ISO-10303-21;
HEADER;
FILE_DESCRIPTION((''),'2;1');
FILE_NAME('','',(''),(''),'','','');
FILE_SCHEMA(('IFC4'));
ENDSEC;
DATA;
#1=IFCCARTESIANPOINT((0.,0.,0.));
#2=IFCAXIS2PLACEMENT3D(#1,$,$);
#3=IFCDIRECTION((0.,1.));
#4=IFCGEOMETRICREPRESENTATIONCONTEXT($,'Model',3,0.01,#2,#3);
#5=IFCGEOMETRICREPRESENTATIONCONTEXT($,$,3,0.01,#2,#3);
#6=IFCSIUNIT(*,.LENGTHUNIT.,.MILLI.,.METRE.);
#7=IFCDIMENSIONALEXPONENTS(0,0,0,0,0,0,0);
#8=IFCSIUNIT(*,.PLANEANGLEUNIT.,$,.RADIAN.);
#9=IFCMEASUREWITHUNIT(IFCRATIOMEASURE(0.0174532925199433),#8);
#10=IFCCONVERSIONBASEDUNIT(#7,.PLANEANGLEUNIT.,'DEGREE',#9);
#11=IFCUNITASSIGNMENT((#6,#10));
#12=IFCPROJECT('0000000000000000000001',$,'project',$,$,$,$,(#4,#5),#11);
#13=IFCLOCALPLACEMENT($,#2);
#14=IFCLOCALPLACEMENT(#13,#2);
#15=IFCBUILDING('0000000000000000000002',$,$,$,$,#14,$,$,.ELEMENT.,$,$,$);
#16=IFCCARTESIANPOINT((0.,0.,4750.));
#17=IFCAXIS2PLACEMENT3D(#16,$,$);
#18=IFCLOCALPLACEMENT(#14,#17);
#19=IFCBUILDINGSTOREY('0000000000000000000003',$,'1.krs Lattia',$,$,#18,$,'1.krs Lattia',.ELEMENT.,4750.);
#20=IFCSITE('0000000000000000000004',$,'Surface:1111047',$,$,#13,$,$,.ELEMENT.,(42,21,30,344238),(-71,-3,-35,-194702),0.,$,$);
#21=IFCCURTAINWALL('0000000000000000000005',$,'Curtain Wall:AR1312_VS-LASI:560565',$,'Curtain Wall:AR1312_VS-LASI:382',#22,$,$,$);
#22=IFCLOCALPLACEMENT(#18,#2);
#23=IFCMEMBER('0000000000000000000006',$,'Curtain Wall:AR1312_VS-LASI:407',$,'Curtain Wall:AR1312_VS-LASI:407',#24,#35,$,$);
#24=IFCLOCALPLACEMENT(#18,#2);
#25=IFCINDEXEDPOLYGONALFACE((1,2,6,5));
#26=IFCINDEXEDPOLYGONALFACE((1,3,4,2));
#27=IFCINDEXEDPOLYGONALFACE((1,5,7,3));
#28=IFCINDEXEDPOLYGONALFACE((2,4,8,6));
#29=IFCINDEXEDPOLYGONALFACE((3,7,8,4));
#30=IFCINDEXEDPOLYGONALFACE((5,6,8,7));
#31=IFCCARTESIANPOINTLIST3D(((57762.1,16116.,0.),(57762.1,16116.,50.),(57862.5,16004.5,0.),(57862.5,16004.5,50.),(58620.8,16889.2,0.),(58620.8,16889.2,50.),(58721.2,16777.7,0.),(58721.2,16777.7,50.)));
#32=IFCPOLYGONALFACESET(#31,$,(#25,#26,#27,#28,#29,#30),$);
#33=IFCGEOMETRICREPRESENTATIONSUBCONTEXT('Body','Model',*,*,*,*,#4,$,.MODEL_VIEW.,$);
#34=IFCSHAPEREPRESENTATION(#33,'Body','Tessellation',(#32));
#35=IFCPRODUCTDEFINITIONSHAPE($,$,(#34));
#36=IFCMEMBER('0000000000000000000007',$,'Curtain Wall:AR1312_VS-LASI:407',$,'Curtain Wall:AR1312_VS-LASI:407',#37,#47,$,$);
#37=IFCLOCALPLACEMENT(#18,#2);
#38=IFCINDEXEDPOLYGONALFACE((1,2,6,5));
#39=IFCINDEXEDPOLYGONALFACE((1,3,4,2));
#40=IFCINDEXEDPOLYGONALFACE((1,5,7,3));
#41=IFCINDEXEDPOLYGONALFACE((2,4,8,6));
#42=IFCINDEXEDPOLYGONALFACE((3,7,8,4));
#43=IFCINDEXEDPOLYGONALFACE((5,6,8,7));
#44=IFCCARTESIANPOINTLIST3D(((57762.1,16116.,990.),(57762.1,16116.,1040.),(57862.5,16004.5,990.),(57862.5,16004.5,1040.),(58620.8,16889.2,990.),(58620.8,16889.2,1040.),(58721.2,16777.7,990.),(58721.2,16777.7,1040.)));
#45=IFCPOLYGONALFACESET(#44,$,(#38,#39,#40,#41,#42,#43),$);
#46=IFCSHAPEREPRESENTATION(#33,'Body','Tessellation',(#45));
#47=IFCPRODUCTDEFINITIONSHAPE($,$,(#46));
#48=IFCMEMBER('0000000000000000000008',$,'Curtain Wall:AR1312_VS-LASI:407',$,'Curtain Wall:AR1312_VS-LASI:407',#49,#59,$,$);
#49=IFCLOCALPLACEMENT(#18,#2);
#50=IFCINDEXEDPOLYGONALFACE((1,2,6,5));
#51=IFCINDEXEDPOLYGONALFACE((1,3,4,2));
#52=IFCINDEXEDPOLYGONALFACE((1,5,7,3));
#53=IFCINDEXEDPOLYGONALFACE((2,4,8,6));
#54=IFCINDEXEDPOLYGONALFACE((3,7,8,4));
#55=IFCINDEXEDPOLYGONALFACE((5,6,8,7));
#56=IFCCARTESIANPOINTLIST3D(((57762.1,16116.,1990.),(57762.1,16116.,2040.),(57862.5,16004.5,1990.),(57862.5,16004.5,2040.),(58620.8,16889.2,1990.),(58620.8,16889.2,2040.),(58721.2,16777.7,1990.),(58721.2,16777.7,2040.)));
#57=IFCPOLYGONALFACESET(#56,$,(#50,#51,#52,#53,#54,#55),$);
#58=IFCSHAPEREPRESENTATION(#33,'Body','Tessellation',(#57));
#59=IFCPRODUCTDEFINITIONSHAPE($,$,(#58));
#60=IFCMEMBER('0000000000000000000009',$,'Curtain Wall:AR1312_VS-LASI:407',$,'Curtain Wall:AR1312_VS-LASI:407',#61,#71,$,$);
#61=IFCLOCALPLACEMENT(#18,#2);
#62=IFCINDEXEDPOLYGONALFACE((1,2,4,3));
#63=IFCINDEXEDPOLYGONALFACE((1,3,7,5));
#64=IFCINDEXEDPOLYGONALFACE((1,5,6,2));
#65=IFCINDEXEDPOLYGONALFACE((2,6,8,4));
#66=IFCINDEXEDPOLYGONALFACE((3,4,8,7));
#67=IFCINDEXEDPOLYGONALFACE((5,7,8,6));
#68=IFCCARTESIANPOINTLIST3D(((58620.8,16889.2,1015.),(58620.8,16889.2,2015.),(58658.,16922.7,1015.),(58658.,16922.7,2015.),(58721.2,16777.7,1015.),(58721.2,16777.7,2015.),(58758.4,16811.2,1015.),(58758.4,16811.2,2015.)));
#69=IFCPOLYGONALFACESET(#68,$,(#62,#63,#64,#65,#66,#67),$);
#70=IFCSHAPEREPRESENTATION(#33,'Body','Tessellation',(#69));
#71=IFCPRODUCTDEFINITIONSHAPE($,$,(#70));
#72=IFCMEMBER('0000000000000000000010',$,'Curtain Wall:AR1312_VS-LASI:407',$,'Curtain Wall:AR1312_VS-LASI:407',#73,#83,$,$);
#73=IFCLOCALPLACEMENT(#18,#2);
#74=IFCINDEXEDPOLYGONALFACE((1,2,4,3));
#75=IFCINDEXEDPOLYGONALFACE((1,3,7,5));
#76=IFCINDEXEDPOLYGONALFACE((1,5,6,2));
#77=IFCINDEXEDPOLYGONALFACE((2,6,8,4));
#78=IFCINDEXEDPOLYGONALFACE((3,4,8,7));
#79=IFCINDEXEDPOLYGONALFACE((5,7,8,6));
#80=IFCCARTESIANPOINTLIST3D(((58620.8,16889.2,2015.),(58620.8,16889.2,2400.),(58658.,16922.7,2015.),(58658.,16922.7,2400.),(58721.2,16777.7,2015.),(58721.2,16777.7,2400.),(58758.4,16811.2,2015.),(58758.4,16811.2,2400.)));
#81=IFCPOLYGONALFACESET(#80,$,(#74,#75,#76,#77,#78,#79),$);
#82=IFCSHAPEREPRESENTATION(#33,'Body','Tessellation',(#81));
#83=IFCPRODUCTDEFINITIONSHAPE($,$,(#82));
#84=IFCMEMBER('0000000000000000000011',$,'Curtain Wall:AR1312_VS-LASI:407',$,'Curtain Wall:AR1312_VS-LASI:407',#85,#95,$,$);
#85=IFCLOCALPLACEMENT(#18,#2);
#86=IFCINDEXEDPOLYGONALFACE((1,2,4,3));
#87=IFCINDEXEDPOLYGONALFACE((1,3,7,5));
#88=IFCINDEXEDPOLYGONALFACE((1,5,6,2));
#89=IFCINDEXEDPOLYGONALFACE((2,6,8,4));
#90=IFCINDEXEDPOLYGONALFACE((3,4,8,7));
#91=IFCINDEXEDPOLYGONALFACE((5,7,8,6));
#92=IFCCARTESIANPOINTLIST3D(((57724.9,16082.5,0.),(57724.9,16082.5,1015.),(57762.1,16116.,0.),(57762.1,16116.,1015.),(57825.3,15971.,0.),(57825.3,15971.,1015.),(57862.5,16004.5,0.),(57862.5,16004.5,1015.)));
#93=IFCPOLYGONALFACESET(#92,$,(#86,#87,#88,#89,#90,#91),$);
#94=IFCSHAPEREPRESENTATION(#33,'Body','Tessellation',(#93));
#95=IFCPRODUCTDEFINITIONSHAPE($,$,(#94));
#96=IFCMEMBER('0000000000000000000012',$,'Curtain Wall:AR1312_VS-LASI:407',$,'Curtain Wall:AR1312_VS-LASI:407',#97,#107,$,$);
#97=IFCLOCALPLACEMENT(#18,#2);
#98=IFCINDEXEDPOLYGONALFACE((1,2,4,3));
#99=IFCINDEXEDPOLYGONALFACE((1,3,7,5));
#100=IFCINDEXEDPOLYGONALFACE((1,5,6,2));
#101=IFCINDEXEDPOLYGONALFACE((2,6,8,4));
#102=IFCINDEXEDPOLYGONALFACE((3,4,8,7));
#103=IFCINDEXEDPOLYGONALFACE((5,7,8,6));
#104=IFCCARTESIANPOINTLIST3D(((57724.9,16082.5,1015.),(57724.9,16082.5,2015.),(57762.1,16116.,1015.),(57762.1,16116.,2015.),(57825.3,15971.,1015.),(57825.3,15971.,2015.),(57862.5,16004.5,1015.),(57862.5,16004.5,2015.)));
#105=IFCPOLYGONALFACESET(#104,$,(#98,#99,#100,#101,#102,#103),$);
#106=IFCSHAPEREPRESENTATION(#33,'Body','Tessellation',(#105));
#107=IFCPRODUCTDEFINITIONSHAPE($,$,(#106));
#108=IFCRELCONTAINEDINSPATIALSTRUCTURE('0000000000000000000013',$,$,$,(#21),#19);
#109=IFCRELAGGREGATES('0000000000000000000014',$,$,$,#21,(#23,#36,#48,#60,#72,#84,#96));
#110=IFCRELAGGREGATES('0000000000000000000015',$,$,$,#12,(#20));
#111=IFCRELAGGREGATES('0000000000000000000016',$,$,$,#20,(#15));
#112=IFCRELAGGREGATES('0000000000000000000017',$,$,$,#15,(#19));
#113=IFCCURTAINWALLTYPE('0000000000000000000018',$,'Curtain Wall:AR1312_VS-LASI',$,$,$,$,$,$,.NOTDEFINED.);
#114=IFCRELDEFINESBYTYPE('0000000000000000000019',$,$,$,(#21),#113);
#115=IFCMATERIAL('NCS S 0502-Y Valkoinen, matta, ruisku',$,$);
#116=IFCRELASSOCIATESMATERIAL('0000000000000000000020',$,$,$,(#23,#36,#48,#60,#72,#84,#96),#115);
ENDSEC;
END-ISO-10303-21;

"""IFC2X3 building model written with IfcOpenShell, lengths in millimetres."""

from ifc_helpers import new_model, entity, si_unit, converted_unit, direction, frame, frame_2d, origin, origin_2d_with_axis, place, context, subcontext, project, spatial, rectangle, extrude, material, type_object, element, aggregate, save


model = new_model("IFC2X3")

# Units and contexts
model_context = context("Model", 3, precision=0.01, world=origin(), true_north=direction((0.0, 1.0)))
context_of_model = context(None, 3, precision=0.01, world=origin(), true_north=direction((0.0, 1.0)))
body_context = subcontext(model_context, "Body", "Model", "MODEL_VIEW")
ifc_project = project(units=[si_unit("LENGTHUNIT", "METRE", prefix="MILLI"), converted_unit("PLANEANGLEUNIT", "DEGREE", entity("IfcRatioMeasure", 0.0174532925199433), si_unit("PLANEANGLEUNIT", "RADIAN"), dimensions=[0, 0, 0, 0, 0, 0, 0])], contexts=[model_context, context_of_model])

# Site, building, storey
site_placement = place(None, origin())
site = spatial("IfcSite", under=ifc_project, at=site_placement, Name="Surface:1111047", CompositionType="ELEMENT", RefLatitude=(42, 21, 30, 344238), RefLongitude=(-71, -3, -35, -194702), RefElevation=0.0)
building_placement = place(site_placement, origin())
building = spatial("IfcBuilding", under=site, at=building_placement, CompositionType="ELEMENT")
storey_placement = place(building_placement, frame((0.0, 0.0, 4750.0)))
storey = spatial("IfcBuildingStorey", under=building, at=storey_placement, Name="1.krs Lattia", LongName="1.krs Lattia", CompositionType="ELEMENT", Elevation=4750.0)

# Shared definitions
curtain_wall_type = type_object("IfcCurtainWallType", Name="Curtain Wall:AR1312_VS-LASI", PredefinedType="NOTDEFINED")
ifc_material = material(Name="NCS S 0502-Y Valkoinen, matta, ruisku")

# Curtain wall, members
curtain_wall_1_placement = place(storey_placement, frame((0.0, 0.0, -4750.0)))
curtain_wall_1 = element("IfcCurtainWall", 1, at=curtain_wall_1_placement, inside=storey, type_object=curtain_wall_type, Name="Curtain Wall:AR1312_VS-LASI:560565", ObjectType="Curtain Wall:AR1312_VS-LASI:382")
member_1_placement = place(curtain_wall_1_placement, frame((0.0, 0.0, 4750.0)))
member_1 = element("IfcMember", 2, at=member_1_placement, material=ifc_material, Name="Curtain Wall:AR1312_VS-LASI:407", ObjectType="Curtain Wall:AR1312_VS-LASI:407", context=body_context, shape_type="SweptSolid", body=[
    extrude(rectangle(XDim=50.0, YDim=150.0, at=frame_2d((0.0, 0.0), x_axis=(1.0, 0.0))), frame((57812.3, 16060.2, 25.0), z_axis=(0.743145, 0.669131, 0.0), x_axis=(0.0, 0.0, -1.0)), (0.0, 0.0, 1.0), 1155.6),
])
member_2_placement = place(curtain_wall_1_placement, frame((0.0, 0.0, 4750.0)))
member_2 = element("IfcMember", 3, at=member_2_placement, material=ifc_material, Name="Curtain Wall:AR1312_VS-LASI:407", ObjectType="Curtain Wall:AR1312_VS-LASI:407", context=body_context, shape_type="SweptSolid", body=[
    extrude(rectangle(XDim=50.0, YDim=150.0, at=origin_2d_with_axis()), frame((58671.0, 16833.5, 1015.0), z_axis=(-0.743145, -0.669131, 0.0), x_axis=(0.0, 0.0, -1.0)), (0.0, 0.0, 1.0), 1155.6),
])
member_3_placement = place(curtain_wall_1_placement, frame((0.0, 0.0, 4750.0)))
member_3 = element("IfcMember", 4, at=member_3_placement, material=ifc_material, Name="Curtain Wall:AR1312_VS-LASI:407", ObjectType="Curtain Wall:AR1312_VS-LASI:407", context=body_context, shape_type="SweptSolid", body=[
    extrude(rectangle(XDim=50.0, YDim=150.0, at=frame_2d((0.0, 0.0), x_axis=(1.0, 0.0))), frame((58671.0, 16833.5, 2015.0), z_axis=(-0.743145, -0.669131, 0.0), x_axis=(0.0, 0.0, -1.0)), (0.0, 0.0, 1.0), 1155.6),
])
member_4_placement = place(curtain_wall_1_placement, frame((0.0, 0.0, 4750.0)))
member_4 = element("IfcMember", 5, at=member_4_placement, material=ifc_material, Name="Curtain Wall:AR1312_VS-LASI:407", ObjectType="Curtain Wall:AR1312_VS-LASI:407", context=body_context, shape_type="SweptSolid", body=[
    extrude(rectangle(XDim=50.0, YDim=150.0, at=frame_2d((0.0, 0.0), x_axis=(1.0, 0.0))), frame((58689.6, 16850.2, 1015.0), z_axis=(0.0, 0.0, 1.0), x_axis=(0.743145, 0.669131, 0.0)), (0.0, 0.0, 1.0), 1000.0),
])
member_5_placement = place(curtain_wall_1_placement, frame((0.0, 0.0, 4750.0)))
member_5 = element("IfcMember", 6, at=member_5_placement, material=ifc_material, Name="Curtain Wall:AR1312_VS-LASI:407", ObjectType="Curtain Wall:AR1312_VS-LASI:407", context=body_context, shape_type="SweptSolid", body=[
    extrude(rectangle(XDim=50.0, YDim=150.0, at=frame_2d((0.0, 0.0), x_axis=(1.0, 0.0))), frame((58689.6, 16850.2, 2015.0), z_axis=(0.0, 0.0, 1.0), x_axis=(0.743145, 0.669131, 0.0)), (0.0, 0.0, 1.0), 385.0),
])
member_6_placement = place(curtain_wall_1_placement, frame((0.0, 0.0, 4750.0)))
member_6 = element("IfcMember", 7, at=member_6_placement, material=ifc_material, Name="Curtain Wall:AR1312_VS-LASI:407", ObjectType="Curtain Wall:AR1312_VS-LASI:407", context=body_context, shape_type="SweptSolid", body=[
    extrude(rectangle(XDim=150.0, YDim=50.0, at=frame_2d((0.0, 0.0), x_axis=(1.0, 0.0))), frame((57793.7, 16043.5, 1015.0), z_axis=(0.0, 0.0, -1.0), x_axis=(0.669131, -0.743145, 0.0)), (0.0, 0.0, 1.0), 1015.0),
])
member_7_placement = place(curtain_wall_1_placement, frame((0.0, 0.0, 4750.0)))
member_7 = element("IfcMember", 8, at=member_7_placement, material=ifc_material, Name="Curtain Wall:AR1312_VS-LASI:407", ObjectType="Curtain Wall:AR1312_VS-LASI:407", context=body_context, shape_type="SweptSolid", body=[
    extrude(rectangle(XDim=150.0, YDim=50.0, at=frame_2d((0.0, 0.0), x_axis=(1.0, 0.0))), frame((57793.7, 16043.5, 2015.0), z_axis=(0.0, 0.0, -1.0), x_axis=(0.669131, -0.743145, 0.0)), (0.0, 0.0, 1.0), 1000.0),
])
aggregate(curtain_wall_1, [member_1, member_2, member_3, member_4, member_5, member_6, member_7])

save(model, "model.ifc")
